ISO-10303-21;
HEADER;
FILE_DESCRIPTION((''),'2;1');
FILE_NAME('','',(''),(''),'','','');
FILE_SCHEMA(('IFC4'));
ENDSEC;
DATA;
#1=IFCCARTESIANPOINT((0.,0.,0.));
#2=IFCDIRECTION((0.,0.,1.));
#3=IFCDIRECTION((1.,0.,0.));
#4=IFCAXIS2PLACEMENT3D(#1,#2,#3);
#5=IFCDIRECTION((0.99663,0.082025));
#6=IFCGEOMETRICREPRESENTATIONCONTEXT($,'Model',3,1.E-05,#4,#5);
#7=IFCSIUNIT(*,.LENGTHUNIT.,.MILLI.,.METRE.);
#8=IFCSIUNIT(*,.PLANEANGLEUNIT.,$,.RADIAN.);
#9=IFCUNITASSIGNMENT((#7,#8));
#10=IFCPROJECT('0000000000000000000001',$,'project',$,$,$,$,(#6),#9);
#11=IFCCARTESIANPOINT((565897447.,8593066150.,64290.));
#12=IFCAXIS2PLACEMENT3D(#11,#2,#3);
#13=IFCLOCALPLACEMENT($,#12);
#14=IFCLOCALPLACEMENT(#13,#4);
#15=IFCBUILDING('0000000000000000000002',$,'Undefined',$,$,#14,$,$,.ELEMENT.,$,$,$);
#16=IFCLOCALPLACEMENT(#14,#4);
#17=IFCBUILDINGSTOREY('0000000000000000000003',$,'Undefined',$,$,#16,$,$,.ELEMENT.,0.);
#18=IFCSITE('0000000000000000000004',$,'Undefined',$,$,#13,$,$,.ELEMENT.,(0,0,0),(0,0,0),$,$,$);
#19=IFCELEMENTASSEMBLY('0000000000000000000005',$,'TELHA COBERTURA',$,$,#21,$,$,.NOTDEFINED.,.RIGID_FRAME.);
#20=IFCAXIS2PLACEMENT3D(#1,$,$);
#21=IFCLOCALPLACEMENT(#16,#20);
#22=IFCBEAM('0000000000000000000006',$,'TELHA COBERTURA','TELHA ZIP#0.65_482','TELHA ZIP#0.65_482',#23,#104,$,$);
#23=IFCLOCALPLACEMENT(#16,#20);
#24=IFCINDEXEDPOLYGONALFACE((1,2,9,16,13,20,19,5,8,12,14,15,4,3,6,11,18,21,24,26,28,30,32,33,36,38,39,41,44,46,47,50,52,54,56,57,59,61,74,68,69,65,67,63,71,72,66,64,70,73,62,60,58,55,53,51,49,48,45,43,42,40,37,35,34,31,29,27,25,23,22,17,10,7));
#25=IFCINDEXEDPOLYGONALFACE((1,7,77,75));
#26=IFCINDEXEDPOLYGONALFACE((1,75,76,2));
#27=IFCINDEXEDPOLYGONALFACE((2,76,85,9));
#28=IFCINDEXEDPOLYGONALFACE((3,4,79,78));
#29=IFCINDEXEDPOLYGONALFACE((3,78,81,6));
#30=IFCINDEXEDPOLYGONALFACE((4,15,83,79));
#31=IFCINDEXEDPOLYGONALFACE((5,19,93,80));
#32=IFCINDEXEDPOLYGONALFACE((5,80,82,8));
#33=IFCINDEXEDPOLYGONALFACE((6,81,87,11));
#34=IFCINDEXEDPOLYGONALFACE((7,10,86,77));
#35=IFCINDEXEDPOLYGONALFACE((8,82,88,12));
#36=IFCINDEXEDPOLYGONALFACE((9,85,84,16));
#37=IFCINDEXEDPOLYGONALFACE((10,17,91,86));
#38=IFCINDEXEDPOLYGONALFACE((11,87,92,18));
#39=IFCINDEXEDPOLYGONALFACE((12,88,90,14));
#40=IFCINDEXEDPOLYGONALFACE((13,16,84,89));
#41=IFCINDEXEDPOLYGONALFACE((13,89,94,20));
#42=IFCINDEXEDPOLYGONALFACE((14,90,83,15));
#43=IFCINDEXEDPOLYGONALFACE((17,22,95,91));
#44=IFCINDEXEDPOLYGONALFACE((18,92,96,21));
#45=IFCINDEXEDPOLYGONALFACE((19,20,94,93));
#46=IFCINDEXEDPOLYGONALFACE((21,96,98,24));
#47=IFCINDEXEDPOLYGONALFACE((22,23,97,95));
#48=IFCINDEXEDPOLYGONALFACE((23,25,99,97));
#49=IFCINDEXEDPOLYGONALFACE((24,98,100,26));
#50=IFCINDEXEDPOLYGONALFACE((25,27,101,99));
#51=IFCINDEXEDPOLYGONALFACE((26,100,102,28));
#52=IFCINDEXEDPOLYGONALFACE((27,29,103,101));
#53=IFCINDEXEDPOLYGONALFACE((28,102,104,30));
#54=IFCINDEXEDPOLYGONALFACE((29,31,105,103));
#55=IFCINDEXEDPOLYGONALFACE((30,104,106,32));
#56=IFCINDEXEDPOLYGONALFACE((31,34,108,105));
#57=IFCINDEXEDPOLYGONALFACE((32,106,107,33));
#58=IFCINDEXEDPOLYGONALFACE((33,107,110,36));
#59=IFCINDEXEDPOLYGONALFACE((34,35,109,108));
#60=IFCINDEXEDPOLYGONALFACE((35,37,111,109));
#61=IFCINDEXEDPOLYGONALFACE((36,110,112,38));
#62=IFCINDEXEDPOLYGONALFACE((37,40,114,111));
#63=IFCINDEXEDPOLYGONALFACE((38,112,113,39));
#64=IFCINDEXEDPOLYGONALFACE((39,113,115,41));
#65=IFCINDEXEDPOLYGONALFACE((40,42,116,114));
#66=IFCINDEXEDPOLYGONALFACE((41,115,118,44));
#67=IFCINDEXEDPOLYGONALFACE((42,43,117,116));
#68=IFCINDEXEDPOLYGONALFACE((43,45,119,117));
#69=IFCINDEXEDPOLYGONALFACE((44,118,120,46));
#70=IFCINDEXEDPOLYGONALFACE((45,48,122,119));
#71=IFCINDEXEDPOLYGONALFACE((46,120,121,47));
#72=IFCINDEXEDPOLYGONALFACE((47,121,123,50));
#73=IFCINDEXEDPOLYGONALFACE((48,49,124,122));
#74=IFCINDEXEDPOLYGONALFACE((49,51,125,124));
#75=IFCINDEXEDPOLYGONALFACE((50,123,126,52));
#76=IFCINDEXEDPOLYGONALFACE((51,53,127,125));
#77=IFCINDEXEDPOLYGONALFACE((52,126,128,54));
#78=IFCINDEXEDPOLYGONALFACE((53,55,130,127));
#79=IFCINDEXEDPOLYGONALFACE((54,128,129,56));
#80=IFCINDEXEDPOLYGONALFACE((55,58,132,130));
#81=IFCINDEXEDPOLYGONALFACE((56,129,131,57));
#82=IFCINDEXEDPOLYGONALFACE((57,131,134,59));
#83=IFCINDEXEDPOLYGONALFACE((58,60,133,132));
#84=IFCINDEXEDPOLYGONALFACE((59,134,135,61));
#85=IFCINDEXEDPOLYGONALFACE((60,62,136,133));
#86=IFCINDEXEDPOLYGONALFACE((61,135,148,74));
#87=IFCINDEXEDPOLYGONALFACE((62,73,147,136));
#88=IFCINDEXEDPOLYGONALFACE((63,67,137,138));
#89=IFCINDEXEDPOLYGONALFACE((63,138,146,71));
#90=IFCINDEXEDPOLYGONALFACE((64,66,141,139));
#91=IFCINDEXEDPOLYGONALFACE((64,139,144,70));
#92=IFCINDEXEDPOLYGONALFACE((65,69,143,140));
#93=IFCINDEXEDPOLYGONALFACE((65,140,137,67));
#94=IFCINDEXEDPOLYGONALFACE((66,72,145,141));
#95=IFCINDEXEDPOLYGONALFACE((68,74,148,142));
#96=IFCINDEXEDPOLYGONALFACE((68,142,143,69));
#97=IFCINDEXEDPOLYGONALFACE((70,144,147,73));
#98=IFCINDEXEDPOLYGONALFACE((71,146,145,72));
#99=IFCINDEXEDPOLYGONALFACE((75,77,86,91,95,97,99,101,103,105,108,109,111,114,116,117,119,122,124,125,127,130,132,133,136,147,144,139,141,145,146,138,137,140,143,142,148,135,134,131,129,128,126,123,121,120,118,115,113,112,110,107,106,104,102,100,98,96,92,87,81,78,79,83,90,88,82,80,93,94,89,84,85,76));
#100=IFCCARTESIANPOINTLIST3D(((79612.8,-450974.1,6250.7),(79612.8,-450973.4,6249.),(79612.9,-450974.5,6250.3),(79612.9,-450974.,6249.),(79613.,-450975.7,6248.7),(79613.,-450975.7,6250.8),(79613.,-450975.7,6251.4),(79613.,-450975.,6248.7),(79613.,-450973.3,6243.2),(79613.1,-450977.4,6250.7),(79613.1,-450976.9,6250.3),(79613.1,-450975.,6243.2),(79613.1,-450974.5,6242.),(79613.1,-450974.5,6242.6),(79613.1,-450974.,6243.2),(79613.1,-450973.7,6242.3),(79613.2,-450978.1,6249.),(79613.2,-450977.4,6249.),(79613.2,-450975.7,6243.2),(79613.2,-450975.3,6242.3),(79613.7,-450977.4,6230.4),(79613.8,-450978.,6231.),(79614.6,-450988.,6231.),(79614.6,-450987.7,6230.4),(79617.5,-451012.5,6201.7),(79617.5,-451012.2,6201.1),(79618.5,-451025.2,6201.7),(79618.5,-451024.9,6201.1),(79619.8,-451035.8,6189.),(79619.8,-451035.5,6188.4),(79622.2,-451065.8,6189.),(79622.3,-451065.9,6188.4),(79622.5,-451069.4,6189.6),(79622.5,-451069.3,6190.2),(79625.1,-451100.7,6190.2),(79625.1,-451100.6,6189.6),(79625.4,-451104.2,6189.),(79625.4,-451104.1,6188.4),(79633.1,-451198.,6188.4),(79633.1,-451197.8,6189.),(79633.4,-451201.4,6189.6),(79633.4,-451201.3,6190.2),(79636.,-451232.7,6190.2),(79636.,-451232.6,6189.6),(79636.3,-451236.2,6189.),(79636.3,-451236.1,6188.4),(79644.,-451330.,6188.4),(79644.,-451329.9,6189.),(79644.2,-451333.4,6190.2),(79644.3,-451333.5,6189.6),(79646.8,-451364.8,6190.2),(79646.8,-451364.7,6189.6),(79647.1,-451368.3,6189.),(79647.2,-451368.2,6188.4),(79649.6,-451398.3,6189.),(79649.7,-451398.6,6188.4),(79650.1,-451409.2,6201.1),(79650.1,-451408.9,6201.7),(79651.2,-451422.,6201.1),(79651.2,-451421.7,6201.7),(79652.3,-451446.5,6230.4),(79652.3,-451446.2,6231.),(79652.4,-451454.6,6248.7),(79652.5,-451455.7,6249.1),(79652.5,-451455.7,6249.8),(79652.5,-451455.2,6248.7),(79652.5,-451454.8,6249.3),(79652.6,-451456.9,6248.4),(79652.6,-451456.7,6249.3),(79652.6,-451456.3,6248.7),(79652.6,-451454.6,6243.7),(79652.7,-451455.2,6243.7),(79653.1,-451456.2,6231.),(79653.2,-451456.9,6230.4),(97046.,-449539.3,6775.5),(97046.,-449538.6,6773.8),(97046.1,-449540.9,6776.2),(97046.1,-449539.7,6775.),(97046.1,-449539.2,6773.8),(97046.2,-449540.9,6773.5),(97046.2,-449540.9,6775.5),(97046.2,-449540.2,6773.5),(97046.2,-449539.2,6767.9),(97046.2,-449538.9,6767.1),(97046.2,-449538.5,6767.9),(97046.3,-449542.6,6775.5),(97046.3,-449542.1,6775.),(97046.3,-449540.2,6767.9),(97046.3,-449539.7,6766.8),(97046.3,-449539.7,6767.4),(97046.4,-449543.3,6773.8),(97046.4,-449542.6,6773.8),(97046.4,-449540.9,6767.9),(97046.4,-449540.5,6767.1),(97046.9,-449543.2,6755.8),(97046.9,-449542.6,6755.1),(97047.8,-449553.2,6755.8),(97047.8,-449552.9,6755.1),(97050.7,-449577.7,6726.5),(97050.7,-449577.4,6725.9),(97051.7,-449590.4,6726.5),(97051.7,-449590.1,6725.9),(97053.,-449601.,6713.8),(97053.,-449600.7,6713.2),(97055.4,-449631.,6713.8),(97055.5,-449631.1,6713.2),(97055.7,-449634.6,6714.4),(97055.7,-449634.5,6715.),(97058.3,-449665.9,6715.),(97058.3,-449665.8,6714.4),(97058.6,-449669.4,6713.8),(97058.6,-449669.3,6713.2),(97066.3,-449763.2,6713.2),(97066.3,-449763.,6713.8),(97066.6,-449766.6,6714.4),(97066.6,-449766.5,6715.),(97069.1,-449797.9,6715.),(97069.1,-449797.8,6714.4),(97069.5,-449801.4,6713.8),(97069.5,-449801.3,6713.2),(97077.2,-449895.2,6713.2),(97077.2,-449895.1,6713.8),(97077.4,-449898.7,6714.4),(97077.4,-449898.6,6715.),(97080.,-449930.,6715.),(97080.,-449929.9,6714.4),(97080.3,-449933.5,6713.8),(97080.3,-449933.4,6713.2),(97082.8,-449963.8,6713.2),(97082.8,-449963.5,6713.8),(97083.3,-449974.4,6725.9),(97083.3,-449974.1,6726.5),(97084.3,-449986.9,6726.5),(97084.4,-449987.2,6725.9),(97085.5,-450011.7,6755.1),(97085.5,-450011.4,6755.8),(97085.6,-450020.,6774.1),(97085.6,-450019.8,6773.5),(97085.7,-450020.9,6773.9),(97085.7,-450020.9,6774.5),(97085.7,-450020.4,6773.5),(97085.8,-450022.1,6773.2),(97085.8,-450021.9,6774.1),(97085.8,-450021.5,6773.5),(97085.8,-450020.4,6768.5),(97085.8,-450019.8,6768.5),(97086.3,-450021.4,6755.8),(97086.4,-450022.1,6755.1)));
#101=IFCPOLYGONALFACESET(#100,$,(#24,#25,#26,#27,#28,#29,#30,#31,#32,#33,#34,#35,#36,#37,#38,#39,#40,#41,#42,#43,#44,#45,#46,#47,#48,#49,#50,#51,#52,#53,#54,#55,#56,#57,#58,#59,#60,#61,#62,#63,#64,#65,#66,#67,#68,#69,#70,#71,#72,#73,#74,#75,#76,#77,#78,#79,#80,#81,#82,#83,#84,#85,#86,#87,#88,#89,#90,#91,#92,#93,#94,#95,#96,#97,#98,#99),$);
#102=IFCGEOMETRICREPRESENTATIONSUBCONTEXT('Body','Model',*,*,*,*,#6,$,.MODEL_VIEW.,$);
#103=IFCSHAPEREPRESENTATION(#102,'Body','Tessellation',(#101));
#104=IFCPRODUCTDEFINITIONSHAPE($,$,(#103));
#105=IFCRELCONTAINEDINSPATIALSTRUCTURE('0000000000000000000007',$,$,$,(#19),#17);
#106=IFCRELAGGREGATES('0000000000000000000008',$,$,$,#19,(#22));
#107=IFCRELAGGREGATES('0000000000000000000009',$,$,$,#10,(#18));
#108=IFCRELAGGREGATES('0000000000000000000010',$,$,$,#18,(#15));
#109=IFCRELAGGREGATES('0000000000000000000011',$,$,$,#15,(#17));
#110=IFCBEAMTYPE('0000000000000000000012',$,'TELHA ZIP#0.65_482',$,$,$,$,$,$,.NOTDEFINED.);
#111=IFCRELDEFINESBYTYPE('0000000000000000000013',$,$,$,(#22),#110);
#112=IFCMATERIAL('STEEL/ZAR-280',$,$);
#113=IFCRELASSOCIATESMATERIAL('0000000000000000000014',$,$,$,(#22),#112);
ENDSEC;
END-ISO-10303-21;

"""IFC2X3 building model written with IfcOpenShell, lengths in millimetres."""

from ifc_helpers import new_model, si_unit, direction, frame, origin_with_axes, place, context, subcontext, project, spatial, polyline, outline, extrude, material, type_object, element, aggregate, save


model = new_model("IFC2X3")

# Units and contexts
model_context = context("Model", 3, precision=1e-05, world=origin_with_axes(), true_north=direction((0.99663, 0.082025)))
body_context = subcontext(model_context, "Body", "Model", "MODEL_VIEW")
ifc_project = project(units=[si_unit("LENGTHUNIT", "METRE", prefix="MILLI"), si_unit("PLANEANGLEUNIT", "RADIAN")], contexts=[model_context])

# Site, building, storey
site_placement = place(None, frame((565897447.0, 8593066150.0, 64290.0), z_axis=(0.0, 0.0, 1.0), x_axis=(1.0, 0.0, 0.0)))
site = spatial("IfcSite", under=ifc_project, at=site_placement, Name="Undefined", CompositionType="ELEMENT", RefLatitude=(0, 0, 0), RefLongitude=(0, 0, 0))
building_placement = place(site_placement, origin_with_axes())
building = spatial("IfcBuilding", under=site, at=building_placement, Name="Undefined", CompositionType="ELEMENT")
storey_placement = place(building_placement, origin_with_axes())
storey = spatial("IfcBuildingStorey", under=building, at=storey_placement, Name="Undefined", CompositionType="ELEMENT", Elevation=0.0)

# Element assembly, beam
ifc_material_1 = material(Name="STEEL/ZAR-280")
beam_type_1 = type_object("IfcBeamType", Name="TELHA ZIP#0.65_482", PredefinedType="NOTDEFINED")
assembly_1_placement = place(storey_placement, origin_with_axes())
assembly_1 = element("IfcElementAssembly", 1, at=assembly_1_placement, inside=storey, Name="TELHA COBERTURA", AssemblyPlace="NOTDEFINED", PredefinedType="RIGID_FRAME")
beam_1_placement = place(assembly_1_placement, frame((79633.6, -451215.1, 6219.6), z_axis=(-0.029885, -0.00246, 0.99955), x_axis=(0.996182, 0.081989, 0.029987)))
beam_1 = element("IfcBeam", 2, at=beam_1_placement, type_object=beam_type_1, material=ifc_material_1, Name="TELHA COBERTURA", Description="TELHA ZIP#0.65_482", ObjectType="TELHA ZIP#0.65_482", context=body_context, shape_type="SweptSolid", body=[
    extrude(outline(polyline([(240.5, 29.7), (241.4, 30.2), (242.4, 29.7), (242.6, 28.9), (242.6, 10.8), (232.2, 10.8), (207.6, -18.5), (194.9, -18.5), (184.2, -31.2), (153.7, -31.2), (150.2, -30.0), (118.9, -30.0), (115.4, -31.2), (21.2, -31.2), (17.7, -30.0), (-13.6, -30.0), (-17.1, -31.2), (-111.3, -31.2), (-114.8, -30.0), (-146.1, -30.0), (-149.6, -31.2), (-180.1, -31.2), (-190.8, -18.5), (-203.6, -18.5), (-228.1, 10.8), (-238.5, 10.8), (-238.5, 29.5), (-239.0, 30.7), (-240.2, 31.2), (-241.4, 30.7), (-241.9, 29.5), (-241.9, 23.6), (-241.4, 23.1), (-240.9, 23.6), (-240.9, 29.1), (-240.2, 29.1), (-240.2, 23.6), (-240.6, 22.8), (-241.4, 22.4), (-242.3, 22.8), (-242.6, 23.6), (-242.6, 29.5), (-241.9, 31.2), (-240.2, 31.9), (-238.5, 31.2), (-237.9, 29.5), (-237.9, 11.4), (-227.8, 11.4), (-203.2, -17.9), (-190.4, -17.9), (-179.8, -30.5), (-149.7, -30.5), (-146.2, -29.4), (-114.7, -29.4), (-111.2, -30.5), (-17.2, -30.5), (-13.7, -29.4), (17.8, -29.4), (21.3, -30.5), (115.3, -30.5), (118.8, -29.4), (150.3, -29.4), (153.8, -30.5), (183.9, -30.5), (194.6, -17.9), (207.4, -17.9), (231.9, 11.4), (241.9, 11.4), (241.9, 29.1), (241.4, 29.5), (240.9, 29.1), (240.9, 24.1), (240.2, 24.1), (240.2, 29.2), (240.5, 29.7)])), frame((17500.0, 0.0, 0.0), z_axis=(-1.0, 0.0, 0.0), x_axis=(0.0, -1.0, 0.0)), (0.0, 0.0, 1.0), 17500.0),
])
aggregate(assembly_1, [beam_1])

save(model, "model.ifc")
